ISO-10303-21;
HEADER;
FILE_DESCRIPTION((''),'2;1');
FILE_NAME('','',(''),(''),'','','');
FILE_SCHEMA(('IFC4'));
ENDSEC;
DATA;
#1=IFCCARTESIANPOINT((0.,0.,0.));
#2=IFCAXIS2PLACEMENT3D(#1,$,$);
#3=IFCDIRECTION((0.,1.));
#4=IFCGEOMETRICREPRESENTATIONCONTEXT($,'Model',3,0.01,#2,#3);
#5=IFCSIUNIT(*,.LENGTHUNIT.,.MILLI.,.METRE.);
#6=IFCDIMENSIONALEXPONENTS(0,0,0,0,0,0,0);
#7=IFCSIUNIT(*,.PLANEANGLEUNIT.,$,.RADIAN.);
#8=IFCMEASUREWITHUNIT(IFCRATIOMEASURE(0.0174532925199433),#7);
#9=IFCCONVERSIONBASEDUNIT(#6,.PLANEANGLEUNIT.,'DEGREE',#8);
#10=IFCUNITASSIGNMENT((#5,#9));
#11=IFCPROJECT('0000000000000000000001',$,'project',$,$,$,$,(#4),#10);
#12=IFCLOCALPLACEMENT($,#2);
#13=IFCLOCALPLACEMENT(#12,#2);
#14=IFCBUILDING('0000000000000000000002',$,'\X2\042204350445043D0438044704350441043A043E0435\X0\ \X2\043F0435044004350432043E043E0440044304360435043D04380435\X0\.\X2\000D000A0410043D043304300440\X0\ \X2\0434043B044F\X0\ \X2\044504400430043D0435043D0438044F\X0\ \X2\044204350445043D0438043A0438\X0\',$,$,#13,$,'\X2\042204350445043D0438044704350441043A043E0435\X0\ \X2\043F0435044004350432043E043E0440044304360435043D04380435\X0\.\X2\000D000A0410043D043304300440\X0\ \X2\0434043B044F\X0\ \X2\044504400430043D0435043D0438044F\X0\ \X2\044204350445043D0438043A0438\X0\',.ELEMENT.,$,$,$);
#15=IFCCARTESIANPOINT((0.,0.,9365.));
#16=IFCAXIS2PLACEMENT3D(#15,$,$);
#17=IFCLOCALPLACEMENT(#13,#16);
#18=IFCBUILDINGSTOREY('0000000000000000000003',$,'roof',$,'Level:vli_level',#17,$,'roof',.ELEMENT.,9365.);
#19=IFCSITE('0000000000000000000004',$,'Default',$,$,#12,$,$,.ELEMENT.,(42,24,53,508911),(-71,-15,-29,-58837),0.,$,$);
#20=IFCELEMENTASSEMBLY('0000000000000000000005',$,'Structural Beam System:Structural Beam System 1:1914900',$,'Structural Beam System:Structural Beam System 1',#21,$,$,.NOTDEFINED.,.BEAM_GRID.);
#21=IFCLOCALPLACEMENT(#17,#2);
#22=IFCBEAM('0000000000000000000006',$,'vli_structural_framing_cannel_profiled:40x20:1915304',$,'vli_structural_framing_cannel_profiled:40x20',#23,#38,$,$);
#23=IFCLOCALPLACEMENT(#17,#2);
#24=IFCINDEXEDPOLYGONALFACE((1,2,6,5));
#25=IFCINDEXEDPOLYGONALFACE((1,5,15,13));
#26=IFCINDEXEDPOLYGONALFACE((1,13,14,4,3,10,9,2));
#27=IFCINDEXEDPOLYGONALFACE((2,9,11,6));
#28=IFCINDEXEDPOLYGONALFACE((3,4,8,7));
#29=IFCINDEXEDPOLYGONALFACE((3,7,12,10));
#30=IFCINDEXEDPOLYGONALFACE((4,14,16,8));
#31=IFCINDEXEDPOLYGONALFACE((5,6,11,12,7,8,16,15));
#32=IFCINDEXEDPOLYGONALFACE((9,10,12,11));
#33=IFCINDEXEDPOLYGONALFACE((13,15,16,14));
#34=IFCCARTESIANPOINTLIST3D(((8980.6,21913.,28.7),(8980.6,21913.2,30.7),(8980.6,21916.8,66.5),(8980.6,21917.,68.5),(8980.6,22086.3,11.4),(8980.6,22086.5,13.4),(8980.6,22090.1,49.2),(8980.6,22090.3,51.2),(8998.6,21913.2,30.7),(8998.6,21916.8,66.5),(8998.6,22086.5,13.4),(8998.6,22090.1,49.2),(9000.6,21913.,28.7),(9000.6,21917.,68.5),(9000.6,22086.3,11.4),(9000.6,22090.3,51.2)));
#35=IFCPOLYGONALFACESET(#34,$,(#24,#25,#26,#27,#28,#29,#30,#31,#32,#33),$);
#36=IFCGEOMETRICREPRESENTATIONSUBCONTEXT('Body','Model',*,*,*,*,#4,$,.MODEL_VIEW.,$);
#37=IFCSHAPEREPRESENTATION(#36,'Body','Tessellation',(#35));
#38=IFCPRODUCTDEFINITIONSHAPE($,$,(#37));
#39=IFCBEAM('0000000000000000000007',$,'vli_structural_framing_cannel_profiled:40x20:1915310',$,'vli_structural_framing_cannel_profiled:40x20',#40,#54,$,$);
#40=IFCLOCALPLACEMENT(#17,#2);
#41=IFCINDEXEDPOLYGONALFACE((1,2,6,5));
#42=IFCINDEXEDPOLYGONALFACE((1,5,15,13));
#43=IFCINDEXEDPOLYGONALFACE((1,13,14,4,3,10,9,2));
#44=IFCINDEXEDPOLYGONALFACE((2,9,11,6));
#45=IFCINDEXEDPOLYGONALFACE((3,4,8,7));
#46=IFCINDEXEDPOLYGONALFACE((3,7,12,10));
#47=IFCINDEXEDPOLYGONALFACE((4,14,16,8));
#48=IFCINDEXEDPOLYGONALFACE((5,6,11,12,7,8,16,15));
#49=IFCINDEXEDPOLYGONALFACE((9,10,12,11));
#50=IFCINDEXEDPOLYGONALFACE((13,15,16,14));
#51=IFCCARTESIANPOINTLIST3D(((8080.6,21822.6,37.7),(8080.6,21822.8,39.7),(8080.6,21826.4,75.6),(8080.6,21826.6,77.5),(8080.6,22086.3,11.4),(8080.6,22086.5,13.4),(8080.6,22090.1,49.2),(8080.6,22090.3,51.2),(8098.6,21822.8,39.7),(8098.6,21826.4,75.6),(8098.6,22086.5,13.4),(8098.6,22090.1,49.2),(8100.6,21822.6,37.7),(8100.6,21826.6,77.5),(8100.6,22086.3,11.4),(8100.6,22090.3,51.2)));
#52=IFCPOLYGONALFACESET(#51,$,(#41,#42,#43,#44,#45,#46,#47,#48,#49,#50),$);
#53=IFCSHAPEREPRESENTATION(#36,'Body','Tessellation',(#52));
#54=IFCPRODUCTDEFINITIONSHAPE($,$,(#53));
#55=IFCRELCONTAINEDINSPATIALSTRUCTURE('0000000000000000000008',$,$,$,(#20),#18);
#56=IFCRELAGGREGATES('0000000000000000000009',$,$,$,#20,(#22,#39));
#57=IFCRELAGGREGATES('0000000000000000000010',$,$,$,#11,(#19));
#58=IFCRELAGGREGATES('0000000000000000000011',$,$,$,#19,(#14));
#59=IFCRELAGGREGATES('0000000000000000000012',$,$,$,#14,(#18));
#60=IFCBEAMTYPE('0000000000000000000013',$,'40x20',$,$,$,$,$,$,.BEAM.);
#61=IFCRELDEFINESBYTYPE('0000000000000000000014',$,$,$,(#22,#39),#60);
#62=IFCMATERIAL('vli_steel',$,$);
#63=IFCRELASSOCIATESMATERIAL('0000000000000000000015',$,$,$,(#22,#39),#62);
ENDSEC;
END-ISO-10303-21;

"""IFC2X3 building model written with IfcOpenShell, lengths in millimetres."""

from ifc_helpers import new_model, entity, si_unit, converted_unit, direction, frame, origin, place, context, subcontext, project, spatial, polyline, outline, extrude, material, type_object, element, aggregate, save


model = new_model("IFC2X3")

# Units and contexts
model_context = context("Model", 3, precision=0.01, world=origin(), true_north=direction((0.0, 1.0)))
body_context = subcontext(model_context, "Body", "Model", "MODEL_VIEW")
ifc_project = project(units=[si_unit("LENGTHUNIT", "METRE", prefix="MILLI"), converted_unit("PLANEANGLEUNIT", "DEGREE", entity("IfcRatioMeasure", 0.0174532925199433), si_unit("PLANEANGLEUNIT", "RADIAN"), dimensions=[0, 0, 0, 0, 0, 0, 0])], contexts=[model_context])

# Site, building, storey
site_placement = place(None, origin())
site = spatial("IfcSite", under=ifc_project, at=site_placement, Name="Default", CompositionType="ELEMENT", RefLatitude=(42, 24, 53, 508911), RefLongitude=(-71, -15, -29, -58837), RefElevation=0.0)
building_placement = place(site_placement, origin())
building = spatial("IfcBuilding", under=site, at=building_placement, Name="Техническое перевооружение.\r\nАнгар для хранения техники", LongName="Техническое перевооружение.\r\nАнгар для хранения техники", CompositionType="ELEMENT")
storey_placement = place(building_placement, frame((0.0, 0.0, 9365.0)))
storey = spatial("IfcBuildingStorey", under=building, at=storey_placement, Name="roof", ObjectType="Level:vli_level", LongName="roof", CompositionType="ELEMENT", Elevation=9365.0)

# Shared definitions
ifc_material = material(Name="vli_steel")

# Element assembly, beams
assembly_placement = place(storey_placement, origin())
assembly = element("IfcElementAssembly", 1, at=assembly_placement, inside=storey, Name="Structural Beam System:Structural Beam System 1:1914900", ObjectType="Structural Beam System:Structural Beam System 1", AssemblyPlace="NOTDEFINED", PredefinedType="BEAM_GRID")
beam_type = type_object("IfcBeamType", Name="40x20", PredefinedType="BEAM")
beam_1_placement = place(assembly_placement, frame((9000.0, 22090.8, 10.9), z_axis=(0.0, 0.099504, 0.995037), x_axis=(0.0, -0.995037, 0.099504)))
beam_1 = element("IfcBeam", 2, at=beam_1_placement, type_object=beam_type, material=ifc_material, Name="vli_structural_framing_cannel_profiled:40x20:1915304", ObjectType="vli_structural_framing_cannel_profiled:40x20", context=body_context, shape_type="SweptSolid", body=[
    extrude(outline(polyline([(-20.0, -9.5), (-18.0, -9.5), (-18.0, 8.5), (18.0, 8.5), (18.0, -9.5), (20.0, -9.5), (20.0, 10.5), (-20.0, 10.5), (-20.0, -9.5)])), frame((4.6, -9.9, 20.0), z_axis=(1.0, 0.0, 0.0), x_axis=(0.0, 0.0, -1.0)), (0.0, 0.0, 1.0), 174.1),
])
beam_2_placement = place(assembly_placement, frame((8100.0, 22090.8, 10.9), z_axis=(0.0, 0.099504, 0.995037), x_axis=(0.0, -0.995037, 0.099504)))
beam_2 = element("IfcBeam", 3, at=beam_2_placement, type_object=beam_type, material=ifc_material, Name="vli_structural_framing_cannel_profiled:40x20:1915310", ObjectType="vli_structural_framing_cannel_profiled:40x20", context=body_context, shape_type="SweptSolid", body=[
    extrude(outline(polyline([(-20.0, -9.5), (-18.0, -9.5), (-18.0, 8.5), (18.0, 8.5), (18.0, -9.5), (20.0, -9.5), (20.0, 10.5), (-20.0, 10.5), (-20.0, -9.5)])), frame((4.6, -9.9, 20.0), z_axis=(1.0, 0.0, 0.0), x_axis=(0.0, 0.0, -1.0)), (0.0, 0.0, 1.0), 265.0),
])
aggregate(assembly, [beam_1, beam_2])

save(model, "model.ifc")
